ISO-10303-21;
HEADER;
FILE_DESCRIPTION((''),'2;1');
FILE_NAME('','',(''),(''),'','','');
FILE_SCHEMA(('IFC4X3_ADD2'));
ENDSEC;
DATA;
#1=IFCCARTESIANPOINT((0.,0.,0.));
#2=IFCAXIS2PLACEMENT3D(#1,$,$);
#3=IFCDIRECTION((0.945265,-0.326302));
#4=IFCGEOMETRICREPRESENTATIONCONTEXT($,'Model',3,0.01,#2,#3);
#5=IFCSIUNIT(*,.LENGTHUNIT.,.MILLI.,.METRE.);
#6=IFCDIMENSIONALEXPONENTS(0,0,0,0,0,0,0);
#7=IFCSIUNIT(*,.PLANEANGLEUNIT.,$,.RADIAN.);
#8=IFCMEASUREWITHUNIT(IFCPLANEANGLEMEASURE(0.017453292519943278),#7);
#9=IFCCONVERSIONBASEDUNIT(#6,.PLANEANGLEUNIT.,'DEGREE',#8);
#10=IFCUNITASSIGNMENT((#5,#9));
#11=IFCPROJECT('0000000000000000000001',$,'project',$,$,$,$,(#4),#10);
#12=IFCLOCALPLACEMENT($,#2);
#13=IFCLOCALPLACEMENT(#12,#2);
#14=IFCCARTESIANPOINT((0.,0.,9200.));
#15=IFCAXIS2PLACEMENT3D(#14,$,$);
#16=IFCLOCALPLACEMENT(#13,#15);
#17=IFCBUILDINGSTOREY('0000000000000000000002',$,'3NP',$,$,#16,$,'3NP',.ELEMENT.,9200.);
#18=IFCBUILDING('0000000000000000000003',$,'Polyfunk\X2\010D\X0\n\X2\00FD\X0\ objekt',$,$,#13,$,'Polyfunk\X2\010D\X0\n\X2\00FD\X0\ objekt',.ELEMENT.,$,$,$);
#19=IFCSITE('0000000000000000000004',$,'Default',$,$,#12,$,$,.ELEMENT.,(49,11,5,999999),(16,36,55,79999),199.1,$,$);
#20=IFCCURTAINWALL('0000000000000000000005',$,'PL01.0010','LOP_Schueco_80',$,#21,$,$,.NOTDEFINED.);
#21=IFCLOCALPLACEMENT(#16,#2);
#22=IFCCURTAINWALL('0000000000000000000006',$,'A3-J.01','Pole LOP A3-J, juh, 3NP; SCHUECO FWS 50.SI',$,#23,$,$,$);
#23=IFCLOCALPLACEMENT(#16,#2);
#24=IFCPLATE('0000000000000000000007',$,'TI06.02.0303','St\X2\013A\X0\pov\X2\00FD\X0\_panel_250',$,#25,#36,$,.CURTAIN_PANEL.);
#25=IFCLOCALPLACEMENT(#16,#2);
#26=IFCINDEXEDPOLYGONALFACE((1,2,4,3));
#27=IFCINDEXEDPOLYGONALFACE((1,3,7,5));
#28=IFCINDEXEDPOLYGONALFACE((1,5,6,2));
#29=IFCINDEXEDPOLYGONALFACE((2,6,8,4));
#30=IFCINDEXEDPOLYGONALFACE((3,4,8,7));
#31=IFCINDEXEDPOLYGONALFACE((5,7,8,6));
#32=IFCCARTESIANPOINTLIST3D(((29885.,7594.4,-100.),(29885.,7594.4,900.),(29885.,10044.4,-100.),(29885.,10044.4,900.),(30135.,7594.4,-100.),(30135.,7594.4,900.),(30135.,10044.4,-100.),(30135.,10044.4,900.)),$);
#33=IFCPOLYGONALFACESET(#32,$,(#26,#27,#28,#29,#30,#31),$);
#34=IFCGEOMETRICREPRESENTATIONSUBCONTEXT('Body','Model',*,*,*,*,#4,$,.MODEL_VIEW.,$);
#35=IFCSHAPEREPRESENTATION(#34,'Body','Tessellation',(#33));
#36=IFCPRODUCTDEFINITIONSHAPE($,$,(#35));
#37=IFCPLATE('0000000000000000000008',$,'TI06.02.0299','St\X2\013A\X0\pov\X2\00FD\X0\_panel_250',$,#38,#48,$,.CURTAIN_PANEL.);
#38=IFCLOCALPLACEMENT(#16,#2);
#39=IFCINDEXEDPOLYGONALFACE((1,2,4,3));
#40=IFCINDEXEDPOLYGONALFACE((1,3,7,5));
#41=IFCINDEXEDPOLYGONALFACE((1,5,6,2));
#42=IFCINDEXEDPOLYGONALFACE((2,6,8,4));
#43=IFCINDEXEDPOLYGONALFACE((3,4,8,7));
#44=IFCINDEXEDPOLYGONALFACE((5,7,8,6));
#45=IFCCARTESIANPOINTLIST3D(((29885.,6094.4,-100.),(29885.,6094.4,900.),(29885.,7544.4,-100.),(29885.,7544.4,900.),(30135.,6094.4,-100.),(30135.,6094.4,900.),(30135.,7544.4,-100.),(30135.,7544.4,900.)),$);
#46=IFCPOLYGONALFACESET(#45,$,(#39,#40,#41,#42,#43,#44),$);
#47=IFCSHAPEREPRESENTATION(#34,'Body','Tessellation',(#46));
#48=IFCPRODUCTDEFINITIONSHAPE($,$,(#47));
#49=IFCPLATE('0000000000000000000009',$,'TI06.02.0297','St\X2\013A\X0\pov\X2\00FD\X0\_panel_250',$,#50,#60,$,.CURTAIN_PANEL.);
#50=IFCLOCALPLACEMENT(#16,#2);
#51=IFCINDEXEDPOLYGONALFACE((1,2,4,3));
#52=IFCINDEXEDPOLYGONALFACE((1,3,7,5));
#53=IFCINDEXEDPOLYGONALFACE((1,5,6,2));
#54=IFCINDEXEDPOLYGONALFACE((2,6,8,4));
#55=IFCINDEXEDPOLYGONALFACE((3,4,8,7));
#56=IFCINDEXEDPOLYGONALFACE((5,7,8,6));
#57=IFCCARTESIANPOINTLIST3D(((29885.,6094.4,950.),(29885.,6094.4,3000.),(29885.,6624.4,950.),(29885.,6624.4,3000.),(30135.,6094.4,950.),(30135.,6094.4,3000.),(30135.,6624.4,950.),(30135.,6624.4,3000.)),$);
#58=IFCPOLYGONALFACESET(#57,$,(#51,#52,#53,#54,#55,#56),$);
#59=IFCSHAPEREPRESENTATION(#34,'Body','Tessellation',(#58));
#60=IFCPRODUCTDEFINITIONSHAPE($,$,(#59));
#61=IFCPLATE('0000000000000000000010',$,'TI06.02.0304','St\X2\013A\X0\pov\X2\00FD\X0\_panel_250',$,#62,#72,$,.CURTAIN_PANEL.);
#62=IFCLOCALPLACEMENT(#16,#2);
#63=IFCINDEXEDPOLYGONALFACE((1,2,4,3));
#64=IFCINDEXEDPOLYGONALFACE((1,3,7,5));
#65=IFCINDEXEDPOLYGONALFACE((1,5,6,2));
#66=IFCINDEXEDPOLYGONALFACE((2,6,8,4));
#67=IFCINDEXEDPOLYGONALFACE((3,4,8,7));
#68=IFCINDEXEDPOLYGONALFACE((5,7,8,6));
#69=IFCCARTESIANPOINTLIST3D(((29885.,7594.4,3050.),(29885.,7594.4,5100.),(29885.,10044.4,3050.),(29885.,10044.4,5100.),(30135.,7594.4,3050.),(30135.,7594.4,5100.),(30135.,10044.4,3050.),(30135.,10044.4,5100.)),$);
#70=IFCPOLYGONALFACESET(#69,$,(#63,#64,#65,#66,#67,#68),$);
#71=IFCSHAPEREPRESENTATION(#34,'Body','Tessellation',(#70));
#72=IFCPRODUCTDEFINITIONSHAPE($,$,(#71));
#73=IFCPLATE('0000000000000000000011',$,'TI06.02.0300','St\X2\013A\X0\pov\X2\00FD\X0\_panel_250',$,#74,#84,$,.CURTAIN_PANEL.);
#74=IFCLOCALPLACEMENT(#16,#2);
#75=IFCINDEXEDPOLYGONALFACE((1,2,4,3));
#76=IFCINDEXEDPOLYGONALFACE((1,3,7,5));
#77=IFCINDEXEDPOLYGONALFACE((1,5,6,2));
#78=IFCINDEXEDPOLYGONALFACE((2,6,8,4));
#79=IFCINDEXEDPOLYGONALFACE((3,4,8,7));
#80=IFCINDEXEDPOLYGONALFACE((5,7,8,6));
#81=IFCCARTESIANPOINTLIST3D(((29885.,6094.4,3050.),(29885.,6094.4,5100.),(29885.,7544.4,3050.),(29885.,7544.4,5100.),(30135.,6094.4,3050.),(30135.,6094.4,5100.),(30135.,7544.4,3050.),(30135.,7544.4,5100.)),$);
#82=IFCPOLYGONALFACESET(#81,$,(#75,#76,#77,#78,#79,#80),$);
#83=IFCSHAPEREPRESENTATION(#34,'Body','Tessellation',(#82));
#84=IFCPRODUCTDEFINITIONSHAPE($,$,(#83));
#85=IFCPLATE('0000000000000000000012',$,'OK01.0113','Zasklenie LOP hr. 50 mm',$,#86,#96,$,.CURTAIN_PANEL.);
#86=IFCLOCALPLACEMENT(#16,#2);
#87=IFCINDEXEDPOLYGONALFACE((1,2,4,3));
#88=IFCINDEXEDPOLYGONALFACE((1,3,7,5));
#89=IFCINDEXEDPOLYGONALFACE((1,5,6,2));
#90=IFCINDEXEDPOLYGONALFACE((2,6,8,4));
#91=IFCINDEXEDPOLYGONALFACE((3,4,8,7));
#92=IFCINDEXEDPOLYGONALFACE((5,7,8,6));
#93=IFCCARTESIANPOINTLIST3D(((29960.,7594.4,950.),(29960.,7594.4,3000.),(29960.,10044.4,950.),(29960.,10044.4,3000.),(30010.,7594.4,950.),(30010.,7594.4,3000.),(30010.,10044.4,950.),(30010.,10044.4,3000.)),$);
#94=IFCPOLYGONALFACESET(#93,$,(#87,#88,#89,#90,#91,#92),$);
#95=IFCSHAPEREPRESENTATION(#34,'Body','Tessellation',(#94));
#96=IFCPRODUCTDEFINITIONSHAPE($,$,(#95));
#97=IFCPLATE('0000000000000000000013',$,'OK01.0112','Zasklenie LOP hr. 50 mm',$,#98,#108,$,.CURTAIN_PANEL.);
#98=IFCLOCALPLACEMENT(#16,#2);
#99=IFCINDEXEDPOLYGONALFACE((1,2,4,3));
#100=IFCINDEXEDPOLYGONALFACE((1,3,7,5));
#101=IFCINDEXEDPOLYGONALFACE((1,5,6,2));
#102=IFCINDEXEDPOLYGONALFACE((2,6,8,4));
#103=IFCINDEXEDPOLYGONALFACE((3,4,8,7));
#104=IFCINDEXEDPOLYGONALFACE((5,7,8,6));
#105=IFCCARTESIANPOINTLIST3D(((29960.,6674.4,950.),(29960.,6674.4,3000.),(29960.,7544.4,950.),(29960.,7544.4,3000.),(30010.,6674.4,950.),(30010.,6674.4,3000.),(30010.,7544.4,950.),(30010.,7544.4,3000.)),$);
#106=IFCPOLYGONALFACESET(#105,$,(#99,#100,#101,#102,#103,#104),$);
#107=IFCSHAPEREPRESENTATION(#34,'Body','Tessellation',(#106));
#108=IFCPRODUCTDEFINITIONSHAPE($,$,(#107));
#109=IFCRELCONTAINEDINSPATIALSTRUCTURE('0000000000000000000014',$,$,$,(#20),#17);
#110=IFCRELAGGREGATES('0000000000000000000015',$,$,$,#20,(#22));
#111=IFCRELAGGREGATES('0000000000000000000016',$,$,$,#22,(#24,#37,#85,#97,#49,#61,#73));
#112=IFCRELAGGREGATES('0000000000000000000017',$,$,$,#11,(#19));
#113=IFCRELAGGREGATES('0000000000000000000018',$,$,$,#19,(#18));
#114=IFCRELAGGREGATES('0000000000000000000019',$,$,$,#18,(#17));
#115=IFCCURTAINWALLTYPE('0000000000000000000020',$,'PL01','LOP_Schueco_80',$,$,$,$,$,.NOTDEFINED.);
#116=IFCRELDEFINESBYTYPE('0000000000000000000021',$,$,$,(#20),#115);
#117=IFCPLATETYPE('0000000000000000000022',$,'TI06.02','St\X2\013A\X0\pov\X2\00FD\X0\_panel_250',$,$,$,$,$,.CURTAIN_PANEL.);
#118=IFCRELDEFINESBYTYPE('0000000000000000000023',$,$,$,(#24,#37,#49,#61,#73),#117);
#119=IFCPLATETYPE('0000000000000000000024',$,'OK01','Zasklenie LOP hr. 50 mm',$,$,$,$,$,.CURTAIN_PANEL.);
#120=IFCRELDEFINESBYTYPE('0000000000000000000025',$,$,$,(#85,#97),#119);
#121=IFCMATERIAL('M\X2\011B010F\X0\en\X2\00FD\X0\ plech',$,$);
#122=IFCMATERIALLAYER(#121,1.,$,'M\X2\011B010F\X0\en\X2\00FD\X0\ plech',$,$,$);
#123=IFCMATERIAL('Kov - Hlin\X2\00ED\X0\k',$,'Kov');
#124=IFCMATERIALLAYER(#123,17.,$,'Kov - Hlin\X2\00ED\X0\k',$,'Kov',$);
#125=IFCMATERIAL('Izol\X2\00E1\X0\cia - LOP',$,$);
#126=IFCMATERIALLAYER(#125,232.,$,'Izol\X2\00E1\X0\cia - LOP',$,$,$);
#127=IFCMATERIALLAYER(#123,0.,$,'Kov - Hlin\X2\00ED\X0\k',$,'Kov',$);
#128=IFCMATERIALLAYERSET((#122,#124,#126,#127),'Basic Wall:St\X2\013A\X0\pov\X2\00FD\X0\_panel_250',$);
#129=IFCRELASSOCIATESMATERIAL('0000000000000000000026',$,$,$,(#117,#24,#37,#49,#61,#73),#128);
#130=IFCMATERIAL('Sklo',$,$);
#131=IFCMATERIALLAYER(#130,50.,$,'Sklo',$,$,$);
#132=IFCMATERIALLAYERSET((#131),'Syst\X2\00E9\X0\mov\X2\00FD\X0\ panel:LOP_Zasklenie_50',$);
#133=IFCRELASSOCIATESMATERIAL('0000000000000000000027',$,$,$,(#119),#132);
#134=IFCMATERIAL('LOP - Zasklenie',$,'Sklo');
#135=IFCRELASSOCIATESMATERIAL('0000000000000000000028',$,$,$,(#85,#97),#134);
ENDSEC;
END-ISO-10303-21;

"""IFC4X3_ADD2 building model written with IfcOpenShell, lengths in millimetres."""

from ifc_helpers import new_model, entity, si_unit, converted_unit, direction, frame, frame_2d, origin, origin_2d_with_axis, place, context, subcontext, project, spatial, rectangle, extrude, source, transform, mapped, material, layer, layer_set, layer_usage, type_object, type_shapes, element, aggregate, save


model = new_model("IFC4X3_ADD2")

# Units and contexts
model_context = context("Model", 3, precision=0.01, world=origin(), true_north=direction((0.945265, -0.326302)))
body_context = subcontext(model_context, "Body", "Model", "MODEL_VIEW")
ifc_project = project(units=[si_unit("LENGTHUNIT", "METRE", prefix="MILLI"), converted_unit("PLANEANGLEUNIT", "DEGREE", entity("IfcPlaneAngleMeasure", 0.017453292519943278), si_unit("PLANEANGLEUNIT", "RADIAN"), dimensions=[0, 0, 0, 0, 0, 0, 0])], contexts=[model_context])

# Site, building, storey
site_placement = place(None, origin())
site = spatial("IfcSite", under=ifc_project, at=site_placement, Name="Default", CompositionType="ELEMENT", RefLatitude=(49, 11, 5, 999999), RefLongitude=(16, 36, 55, 79999), RefElevation=199.1)
building_placement = place(site_placement, origin())
building = spatial("IfcBuilding", under=site, at=building_placement, Name="Polyfunkčný objekt", LongName="Polyfunkčný objekt", CompositionType="ELEMENT")
storey_placement = place(building_placement, frame((0.0, 0.0, 9200.0)))
storey = spatial("IfcBuildingStorey", under=building, at=storey_placement, Name="3NP", LongName="3NP", CompositionType="ELEMENT", Elevation=9200.0)

# Curtain walls, plates
curtain_wall_type = type_object("IfcCurtainWallType", Name="PL01", Description="LOP_Schueco_80", PredefinedType="NOTDEFINED")
curtain_wall_1_placement = place(storey_placement, frame((0.0, 0.0, -9200.0)))
curtain_wall_1 = element("IfcCurtainWall", 1, at=curtain_wall_1_placement, inside=storey, type_object=curtain_wall_type, Name="PL01.0010", Description="LOP_Schueco_80", PredefinedType="NOTDEFINED")
curtain_wall_2 = element("IfcCurtainWall", 2, Name="A3-J.01", Description="Pole LOP A3-J, juh, 3NP; SCHUECO FWS 50.SI")
aggregate(curtain_wall_1, [curtain_wall_2])
ifc_material_1 = material(Name="Měďený plech")
ifc_layer_1 = layer(ifc_material_1, 1.0, Name="Měďený plech")
ifc_material_2 = material(Name="Kov - Hliník", Category="Kov")
ifc_layer_2 = layer(ifc_material_2, 17.0, Name="Kov - Hliník", Category="Kov")
ifc_material_3 = material(Name="Izolácia - LOP")
ifc_layer_3 = layer(ifc_material_3, 232.0, Name="Izolácia - LOP")
ifc_layer_4 = layer(ifc_material_2, 0.0, Name="Kov - Hliník", Category="Kov")
ifc_layer_set_1 = layer_set([ifc_layer_1, ifc_layer_2, ifc_layer_3, ifc_layer_4], Name="Basic Wall:Stĺpový_panel_250")
ifc_layer_usage_1 = layer_usage(ifc_layer_set_1, "AXIS2", "POSITIVE", -125.0)
plate_type_1 = type_object("IfcPlateType", Name="TI06.02", Description="Stĺpový_panel_250", PredefinedType="CURTAIN_PANEL", material=ifc_layer_set_1)
plate_1_placement = place(storey_placement, frame((30010.0, 10044.4, -100.0), z_axis=(0.0, 0.0, 1.0), x_axis=(0.0, -1.0, 0.0)))
plate_1 = element("IfcPlate", 3, at=plate_1_placement, type_object=plate_type_1, material=ifc_layer_usage_1, Name="TI06.02.0303", Description="Stĺpový_panel_250", PredefinedType="CURTAIN_PANEL", context=body_context, shape_type="SweptSolid", body=[
    extrude(rectangle(XDim=250.0, YDim=2450.0, at=origin_2d_with_axis()), frame((1225.0, 0.0, 0.0), z_axis=(0.0, 0.0, 1.0), x_axis=(0.0, 1.0, 0.0)), (0.0, 0.0, 1.0), 1000.0),
])
ifc_layer_usage_2 = layer_usage(ifc_layer_set_1, "AXIS2", "POSITIVE", -125.0)
plate_2_placement = place(storey_placement, frame((30010.0, 7544.4, -100.0), z_axis=(0.0, 0.0, 1.0), x_axis=(0.0, -1.0, 0.0)))
plate_2 = element("IfcPlate", 4, at=plate_2_placement, type_object=plate_type_1, material=ifc_layer_usage_2, Name="TI06.02.0299", Description="Stĺpový_panel_250", PredefinedType="CURTAIN_PANEL", context=body_context, shape_type="SweptSolid", body=[
    extrude(rectangle(XDim=250.0, YDim=1450.0, at=frame_2d((0.0, 0.0), x_axis=(1.0, 0.0))), frame((725.0, 0.0, 0.0), z_axis=(0.0, 0.0, 1.0), x_axis=(0.0, 1.0, 0.0)), (0.0, 0.0, 1.0), 1000.0),
])
ifc_layer_usage_3 = layer_usage(ifc_layer_set_1, "AXIS2", "POSITIVE", -125.0)
plate_3_placement = place(storey_placement, frame((30010.0, 6624.4, 950.0), z_axis=(0.0, 0.0, 1.0), x_axis=(0.0, -1.0, 0.0)))
plate_3 = element("IfcPlate", 5, at=plate_3_placement, type_object=plate_type_1, material=ifc_layer_usage_3, Name="TI06.02.0297", Description="Stĺpový_panel_250", PredefinedType="CURTAIN_PANEL", context=body_context, shape_type="SweptSolid", body=[
    extrude(rectangle(XDim=250.0, YDim=530.0, at=frame_2d((0.0, 0.0), x_axis=(1.0, 0.0))), frame((265.0, 0.0, 0.0), z_axis=(0.0, 0.0, 1.0), x_axis=(0.0, 1.0, 0.0)), (0.0, 0.0, 1.0), 2050.0),
])
ifc_layer_usage_4 = layer_usage(ifc_layer_set_1, "AXIS2", "POSITIVE", -125.0)
plate_4_placement = place(storey_placement, frame((30010.0, 10044.4, 3050.0), z_axis=(0.0, 0.0, 1.0), x_axis=(0.0, -1.0, 0.0)))
plate_4 = element("IfcPlate", 6, at=plate_4_placement, type_object=plate_type_1, material=ifc_layer_usage_4, Name="TI06.02.0304", Description="Stĺpový_panel_250", PredefinedType="CURTAIN_PANEL", context=body_context, shape_type="SweptSolid", body=[
    extrude(rectangle(XDim=250.0, YDim=2450.0, at=frame_2d((0.0, 0.0), x_axis=(1.0, 0.0))), frame((1225.0, 0.0, 0.0), z_axis=(0.0, 0.0, 1.0), x_axis=(0.0, 1.0, 0.0)), (0.0, 0.0, 1.0), 2050.0),
])
ifc_layer_usage_5 = layer_usage(ifc_layer_set_1, "AXIS2", "POSITIVE", -125.0)
plate_5_placement = place(storey_placement, frame((30010.0, 7544.4, 3050.0), z_axis=(0.0, 0.0, 1.0), x_axis=(0.0, -1.0, 0.0)))
plate_5 = element("IfcPlate", 7, at=plate_5_placement, type_object=plate_type_1, material=ifc_layer_usage_5, Name="TI06.02.0300", Description="Stĺpový_panel_250", PredefinedType="CURTAIN_PANEL", context=body_context, shape_type="SweptSolid", body=[
    extrude(rectangle(XDim=250.0, YDim=1450.0, at=frame_2d((0.0, 0.0), x_axis=(1.0, 0.0))), frame((725.0, 0.0, 0.0), z_axis=(0.0, 0.0, 1.0), x_axis=(0.0, 1.0, 0.0)), (0.0, 0.0, 1.0), 2050.0),
])
ifc_material_4 = material(Name="LOP - Zasklenie", Category="Sklo")
ifc_material_5 = material(Name="Sklo")
ifc_layer_5 = layer(ifc_material_5, 50.0, Name="Sklo")
ifc_layer_set_2 = layer_set([ifc_layer_5], Name="Systémový panel:LOP_Zasklenie_50")
plate_type_2 = type_object("IfcPlateType", Name="OK01", Description="Zasklenie LOP hr. 50 mm", PredefinedType="CURTAIN_PANEL", material=ifc_layer_set_2)
shared_shape_1 = source(origin(), body_context, "Body", "SweptSolid", [
    extrude(rectangle(XDim=50.0, YDim=2450.0, at=origin_2d_with_axis()), frame((0.0, -25.0, 0.0), z_axis=(0.0, 0.0, 1.0), x_axis=(0.0, 1.0, 0.0)), (0.0, 0.0, 1.0), 2050.0),
])
plate_6_placement = place(curtain_wall_1_placement, frame((30010.0, 8819.4, 10150.0), z_axis=(0.0, 0.0, 1.0), x_axis=(0.0, -1.0, 0.0)))
plate_6 = element("IfcPlate", 8, at=plate_6_placement, type_object=plate_type_2, material=ifc_material_4, Name="OK01.0113", Description="Zasklenie LOP hr. 50 mm", PredefinedType="CURTAIN_PANEL", context=body_context, shape_type="MappedRepresentation", body=[
    mapped(shared_shape_1, transform((0.0, 0.0, 0.0), scale=1.0)),
])
shared_shape_2 = source(origin(), body_context, "Body", "SweptSolid", [
    extrude(rectangle(XDim=50.0, YDim=870.0, at=origin_2d_with_axis()), frame((0.0, -25.0, 0.0), z_axis=(0.0, 0.0, 1.0), x_axis=(0.0, 1.0, 0.0)), (0.0, 0.0, 1.0), 2050.0),
])
type_shapes(plate_type_2, [shared_shape_1, shared_shape_2])
plate_7_placement = place(curtain_wall_1_placement, frame((30010.0, 7109.4, 10150.0), z_axis=(0.0, 0.0, 1.0), x_axis=(0.0, -1.0, 0.0)))
plate_7 = element("IfcPlate", 9, at=plate_7_placement, type_object=plate_type_2, material=ifc_material_4, Name="OK01.0112", Description="Zasklenie LOP hr. 50 mm", PredefinedType="CURTAIN_PANEL", context=body_context, shape_type="MappedRepresentation", body=[
    mapped(shared_shape_2, transform((0.0, 0.0, 0.0), scale=1.0)),
])
aggregate(curtain_wall_2, [plate_1, plate_2, plate_6, plate_7, plate_3, plate_4, plate_5])

save(model, "model.ifc")
